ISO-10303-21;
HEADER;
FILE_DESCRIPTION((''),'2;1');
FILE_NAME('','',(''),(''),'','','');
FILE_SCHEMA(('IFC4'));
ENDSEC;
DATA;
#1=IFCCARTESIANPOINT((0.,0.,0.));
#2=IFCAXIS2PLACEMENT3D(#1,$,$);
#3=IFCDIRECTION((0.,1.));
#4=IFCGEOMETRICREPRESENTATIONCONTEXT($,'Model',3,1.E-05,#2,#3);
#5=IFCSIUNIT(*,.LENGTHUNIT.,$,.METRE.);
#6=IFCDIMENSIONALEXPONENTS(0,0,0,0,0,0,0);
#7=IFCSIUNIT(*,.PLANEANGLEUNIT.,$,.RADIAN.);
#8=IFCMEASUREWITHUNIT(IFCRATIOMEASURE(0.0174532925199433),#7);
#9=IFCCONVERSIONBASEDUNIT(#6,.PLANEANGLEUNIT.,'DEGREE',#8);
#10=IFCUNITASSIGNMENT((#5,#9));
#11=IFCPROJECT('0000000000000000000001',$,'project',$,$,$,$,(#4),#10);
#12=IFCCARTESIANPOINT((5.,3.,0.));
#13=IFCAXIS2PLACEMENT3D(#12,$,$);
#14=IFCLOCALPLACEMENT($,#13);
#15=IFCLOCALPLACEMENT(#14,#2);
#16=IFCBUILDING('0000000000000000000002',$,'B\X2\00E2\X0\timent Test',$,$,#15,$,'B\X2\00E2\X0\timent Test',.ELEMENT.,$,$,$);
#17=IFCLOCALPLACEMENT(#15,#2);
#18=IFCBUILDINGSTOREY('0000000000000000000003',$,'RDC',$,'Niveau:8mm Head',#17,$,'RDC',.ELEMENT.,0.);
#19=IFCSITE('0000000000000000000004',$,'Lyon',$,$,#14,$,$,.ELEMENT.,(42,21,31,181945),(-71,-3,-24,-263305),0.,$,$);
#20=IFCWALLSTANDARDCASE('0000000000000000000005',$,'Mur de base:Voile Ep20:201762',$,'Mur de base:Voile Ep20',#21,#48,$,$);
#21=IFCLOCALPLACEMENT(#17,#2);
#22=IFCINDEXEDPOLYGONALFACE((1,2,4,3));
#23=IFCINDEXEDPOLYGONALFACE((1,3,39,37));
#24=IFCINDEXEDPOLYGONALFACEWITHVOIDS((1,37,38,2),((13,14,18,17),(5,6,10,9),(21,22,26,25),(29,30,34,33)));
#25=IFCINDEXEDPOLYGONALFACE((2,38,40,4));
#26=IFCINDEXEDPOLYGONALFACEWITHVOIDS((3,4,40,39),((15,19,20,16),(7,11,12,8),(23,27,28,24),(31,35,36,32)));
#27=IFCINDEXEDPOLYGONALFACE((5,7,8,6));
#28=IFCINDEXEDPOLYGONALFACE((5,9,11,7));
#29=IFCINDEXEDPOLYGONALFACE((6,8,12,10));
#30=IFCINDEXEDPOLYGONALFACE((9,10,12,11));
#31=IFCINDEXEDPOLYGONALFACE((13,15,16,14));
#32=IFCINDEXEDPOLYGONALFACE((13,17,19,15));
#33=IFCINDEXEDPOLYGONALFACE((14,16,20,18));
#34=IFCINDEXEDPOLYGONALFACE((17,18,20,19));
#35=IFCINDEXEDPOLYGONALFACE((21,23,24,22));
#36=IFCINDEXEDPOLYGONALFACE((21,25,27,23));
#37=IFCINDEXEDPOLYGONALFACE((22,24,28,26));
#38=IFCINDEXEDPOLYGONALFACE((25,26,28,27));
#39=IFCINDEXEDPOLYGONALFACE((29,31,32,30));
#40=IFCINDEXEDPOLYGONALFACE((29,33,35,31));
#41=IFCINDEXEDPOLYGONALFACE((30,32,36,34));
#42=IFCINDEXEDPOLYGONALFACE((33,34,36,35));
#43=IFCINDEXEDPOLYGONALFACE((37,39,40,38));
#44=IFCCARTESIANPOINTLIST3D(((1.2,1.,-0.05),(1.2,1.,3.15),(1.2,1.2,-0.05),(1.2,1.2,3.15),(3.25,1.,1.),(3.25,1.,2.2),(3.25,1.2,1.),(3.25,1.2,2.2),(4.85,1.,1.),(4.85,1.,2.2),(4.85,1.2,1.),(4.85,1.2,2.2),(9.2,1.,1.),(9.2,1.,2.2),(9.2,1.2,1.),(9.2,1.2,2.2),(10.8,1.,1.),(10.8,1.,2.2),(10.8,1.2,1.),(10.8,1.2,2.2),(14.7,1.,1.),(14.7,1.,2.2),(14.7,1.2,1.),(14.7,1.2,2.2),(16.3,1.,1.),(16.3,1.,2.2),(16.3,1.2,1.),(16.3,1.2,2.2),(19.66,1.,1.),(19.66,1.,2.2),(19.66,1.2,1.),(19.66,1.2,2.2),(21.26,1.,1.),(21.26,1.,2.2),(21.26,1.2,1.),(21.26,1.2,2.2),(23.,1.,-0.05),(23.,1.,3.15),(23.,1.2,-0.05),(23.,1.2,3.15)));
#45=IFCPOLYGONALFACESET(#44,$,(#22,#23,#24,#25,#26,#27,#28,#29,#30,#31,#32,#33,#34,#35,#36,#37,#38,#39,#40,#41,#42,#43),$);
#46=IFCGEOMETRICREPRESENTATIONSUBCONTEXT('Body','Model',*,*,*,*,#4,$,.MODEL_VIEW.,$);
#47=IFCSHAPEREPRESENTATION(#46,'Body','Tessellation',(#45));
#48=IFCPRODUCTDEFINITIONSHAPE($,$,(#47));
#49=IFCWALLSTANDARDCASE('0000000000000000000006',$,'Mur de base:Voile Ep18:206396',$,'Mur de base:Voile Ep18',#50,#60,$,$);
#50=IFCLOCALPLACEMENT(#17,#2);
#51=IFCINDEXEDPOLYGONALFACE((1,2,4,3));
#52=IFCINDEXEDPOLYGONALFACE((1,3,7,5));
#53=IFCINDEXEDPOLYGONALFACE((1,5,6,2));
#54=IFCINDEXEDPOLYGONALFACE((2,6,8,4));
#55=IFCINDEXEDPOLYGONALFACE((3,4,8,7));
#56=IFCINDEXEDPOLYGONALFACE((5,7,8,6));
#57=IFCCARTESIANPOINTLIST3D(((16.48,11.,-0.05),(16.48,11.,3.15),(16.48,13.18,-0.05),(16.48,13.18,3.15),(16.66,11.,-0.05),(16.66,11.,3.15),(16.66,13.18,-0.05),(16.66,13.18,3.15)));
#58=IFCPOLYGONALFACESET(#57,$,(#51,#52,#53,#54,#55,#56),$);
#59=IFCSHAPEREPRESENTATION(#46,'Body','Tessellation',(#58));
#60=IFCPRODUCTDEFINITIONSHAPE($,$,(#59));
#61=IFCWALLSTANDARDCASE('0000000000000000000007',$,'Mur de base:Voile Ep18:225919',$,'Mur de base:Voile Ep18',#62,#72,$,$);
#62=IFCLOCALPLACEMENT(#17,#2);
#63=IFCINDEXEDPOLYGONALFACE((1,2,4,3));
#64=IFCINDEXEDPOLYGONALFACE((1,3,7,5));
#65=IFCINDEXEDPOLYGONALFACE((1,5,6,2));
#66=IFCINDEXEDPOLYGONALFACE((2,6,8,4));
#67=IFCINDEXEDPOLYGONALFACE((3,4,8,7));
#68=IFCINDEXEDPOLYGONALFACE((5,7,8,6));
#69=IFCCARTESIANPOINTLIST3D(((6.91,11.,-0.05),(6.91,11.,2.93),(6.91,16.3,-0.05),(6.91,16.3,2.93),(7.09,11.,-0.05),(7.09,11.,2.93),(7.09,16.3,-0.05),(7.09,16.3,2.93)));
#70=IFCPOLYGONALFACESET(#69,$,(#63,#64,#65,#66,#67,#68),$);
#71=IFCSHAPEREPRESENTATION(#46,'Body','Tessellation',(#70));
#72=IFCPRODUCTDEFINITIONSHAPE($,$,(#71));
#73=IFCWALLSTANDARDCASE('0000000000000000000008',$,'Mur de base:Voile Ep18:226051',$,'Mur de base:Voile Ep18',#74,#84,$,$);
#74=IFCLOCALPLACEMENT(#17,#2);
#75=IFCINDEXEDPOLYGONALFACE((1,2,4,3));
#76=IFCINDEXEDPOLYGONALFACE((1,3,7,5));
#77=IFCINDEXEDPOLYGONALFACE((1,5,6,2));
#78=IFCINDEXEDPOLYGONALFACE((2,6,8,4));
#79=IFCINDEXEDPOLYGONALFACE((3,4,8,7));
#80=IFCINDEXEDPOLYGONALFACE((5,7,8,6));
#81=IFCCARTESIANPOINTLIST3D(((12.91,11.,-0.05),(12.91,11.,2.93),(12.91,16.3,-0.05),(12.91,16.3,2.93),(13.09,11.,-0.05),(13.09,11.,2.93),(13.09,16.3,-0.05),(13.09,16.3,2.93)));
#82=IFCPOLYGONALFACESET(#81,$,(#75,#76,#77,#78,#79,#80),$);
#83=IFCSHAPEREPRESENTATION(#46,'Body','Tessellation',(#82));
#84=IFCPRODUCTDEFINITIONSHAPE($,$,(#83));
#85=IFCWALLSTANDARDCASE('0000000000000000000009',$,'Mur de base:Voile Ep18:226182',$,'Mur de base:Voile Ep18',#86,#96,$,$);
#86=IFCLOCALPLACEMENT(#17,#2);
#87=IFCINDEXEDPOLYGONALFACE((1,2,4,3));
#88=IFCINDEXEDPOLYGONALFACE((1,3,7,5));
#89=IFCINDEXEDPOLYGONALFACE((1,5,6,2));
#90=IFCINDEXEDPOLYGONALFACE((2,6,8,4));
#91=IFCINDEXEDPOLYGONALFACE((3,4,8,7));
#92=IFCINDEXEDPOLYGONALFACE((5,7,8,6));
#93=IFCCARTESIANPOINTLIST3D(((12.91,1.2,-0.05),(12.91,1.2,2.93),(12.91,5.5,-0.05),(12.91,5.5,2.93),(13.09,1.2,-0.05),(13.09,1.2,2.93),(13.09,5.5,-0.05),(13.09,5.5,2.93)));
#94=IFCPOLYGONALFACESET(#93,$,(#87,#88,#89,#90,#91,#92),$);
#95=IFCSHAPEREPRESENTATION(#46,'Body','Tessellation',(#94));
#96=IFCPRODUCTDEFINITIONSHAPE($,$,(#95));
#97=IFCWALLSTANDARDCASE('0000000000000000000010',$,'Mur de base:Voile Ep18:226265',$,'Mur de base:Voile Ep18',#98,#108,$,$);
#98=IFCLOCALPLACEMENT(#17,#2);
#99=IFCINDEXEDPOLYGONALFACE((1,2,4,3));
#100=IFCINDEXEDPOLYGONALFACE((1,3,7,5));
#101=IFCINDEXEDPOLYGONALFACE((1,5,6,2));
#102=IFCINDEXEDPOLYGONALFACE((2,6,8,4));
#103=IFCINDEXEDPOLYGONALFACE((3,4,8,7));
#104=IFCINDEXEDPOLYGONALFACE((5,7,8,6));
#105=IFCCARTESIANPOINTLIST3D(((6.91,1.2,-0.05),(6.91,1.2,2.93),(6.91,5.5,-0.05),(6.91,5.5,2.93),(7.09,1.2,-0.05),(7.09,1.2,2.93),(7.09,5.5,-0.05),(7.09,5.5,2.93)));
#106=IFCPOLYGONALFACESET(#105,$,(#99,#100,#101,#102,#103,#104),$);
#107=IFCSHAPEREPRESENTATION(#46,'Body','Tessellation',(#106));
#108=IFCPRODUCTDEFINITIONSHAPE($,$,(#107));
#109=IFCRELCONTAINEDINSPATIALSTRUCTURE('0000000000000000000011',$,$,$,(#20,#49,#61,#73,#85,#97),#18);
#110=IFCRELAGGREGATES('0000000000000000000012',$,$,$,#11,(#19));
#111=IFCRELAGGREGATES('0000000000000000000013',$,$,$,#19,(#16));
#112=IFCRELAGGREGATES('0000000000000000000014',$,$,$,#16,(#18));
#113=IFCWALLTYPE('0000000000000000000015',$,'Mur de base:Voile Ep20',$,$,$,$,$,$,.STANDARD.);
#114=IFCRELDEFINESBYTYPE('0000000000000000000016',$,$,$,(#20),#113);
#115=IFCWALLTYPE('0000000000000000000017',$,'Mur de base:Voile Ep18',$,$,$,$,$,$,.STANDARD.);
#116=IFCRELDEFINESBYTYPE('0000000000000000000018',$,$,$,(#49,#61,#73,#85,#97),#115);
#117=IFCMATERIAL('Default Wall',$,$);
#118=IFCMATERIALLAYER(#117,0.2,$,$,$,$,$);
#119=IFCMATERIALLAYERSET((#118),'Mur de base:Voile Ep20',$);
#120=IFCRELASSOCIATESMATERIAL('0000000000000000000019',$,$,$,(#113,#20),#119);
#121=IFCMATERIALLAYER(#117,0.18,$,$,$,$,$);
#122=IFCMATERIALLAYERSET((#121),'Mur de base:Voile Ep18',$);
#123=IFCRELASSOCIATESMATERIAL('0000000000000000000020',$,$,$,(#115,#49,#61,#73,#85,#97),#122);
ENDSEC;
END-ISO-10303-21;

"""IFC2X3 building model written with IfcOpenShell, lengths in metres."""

from ifc_helpers import new_model, entity, si_unit, converted_unit, direction, frame, frame_2d, origin, place, context, subcontext, project, spatial, rectangle, extrude, material, layer, layer_set, layer_usage, type_object, element, save


model = new_model("IFC2X3")

# Units and contexts
model_context = context("Model", 3, precision=1e-05, world=origin(), true_north=direction((0.0, 1.0)))
body_context = subcontext(model_context, "Body", "Model", "MODEL_VIEW")
ifc_project = project(units=[si_unit("LENGTHUNIT", "METRE"), converted_unit("PLANEANGLEUNIT", "DEGREE", entity("IfcRatioMeasure", 0.0174532925199433), si_unit("PLANEANGLEUNIT", "RADIAN"), dimensions=[0, 0, 0, 0, 0, 0, 0])], contexts=[model_context])

# Site, building, storey
site_placement = place(None, frame((5.0, 3.0, 0.0)))
site = spatial("IfcSite", under=ifc_project, at=site_placement, Name="Lyon", CompositionType="ELEMENT", RefLatitude=(42, 21, 31, 181945), RefLongitude=(-71, -3, -24, -263305), RefElevation=0.0)
building_placement = place(site_placement, origin())
building = spatial("IfcBuilding", under=site, at=building_placement, Name="Bâtiment Test", LongName="Bâtiment Test", CompositionType="ELEMENT")
storey_placement = place(building_placement, origin())
storey = spatial("IfcBuildingStorey", under=building, at=storey_placement, Name="RDC", ObjectType="Niveau:8mm Head", LongName="RDC", CompositionType="ELEMENT", Elevation=0.0)

# Shared definitions
ifc_material_1 = material(Name="Default Wall")
ifc_layer_1 = layer(ifc_material_1, 0.2)
ifc_layer_set_1 = layer_set([ifc_layer_1], Name="Mur de base:Voile Ep20")
wall_type_1 = type_object("IfcWallType", Name="Mur de base:Voile Ep20", PredefinedType="STANDARD", material=ifc_layer_set_1)

# Wall, openings
ifc_layer_usage_1 = layer_usage(ifc_layer_set_1, "AXIS2", "POSITIVE", -0.1)
wall_1_placement = place(storey_placement, frame((1.2, 1.1, -0.05)))
wall_1 = element("IfcWallStandardCase", 1, at=wall_1_placement, inside=storey, type_object=wall_type_1, material=ifc_layer_usage_1, Name="Mur de base:Voile Ep20:201762", ObjectType="Mur de base:Voile Ep20", context=body_context, shape_type="SweptSolid", body=[
    extrude(rectangle(XDim=21.8, YDim=0.2, at=frame_2d((10.9, 0.0), x_axis=(-1.0, 0.0))), origin(), (0.0, 0.0, 1.0), 3.2),
])
opening_1_placement = place(wall_1_placement, origin())
element("IfcOpeningElement", 2, at=opening_1_placement, cuts=wall_1, ObjectType="Opening", context=body_context, shape_type="SweptSolid", body=[
    extrude(rectangle(XDim=1.2, YDim=1.6, at=frame_2d((0.0, 0.0), x_axis=(0.0, 1.0))), frame((2.85, -0.1, 1.65), z_axis=(0.0, 1.0, 0.0), x_axis=(1.0, 0.0, 0.0)), (0.0, 0.0, 1.0), 0.2),
])
opening_2_placement = place(wall_1_placement, origin())
element("IfcOpeningElement", 3, at=opening_2_placement, cuts=wall_1, ObjectType="Opening", context=body_context, shape_type="SweptSolid", body=[
    extrude(rectangle(XDim=1.2, YDim=1.6, at=frame_2d((0.0, 0.0), x_axis=(1.0, 0.0))), frame((8.8, -0.1, 1.65), z_axis=(0.0, 1.0, 0.0), x_axis=(0.0, 0.0, -1.0)), (0.0, 0.0, 1.0), 0.2),
])
opening_3_placement = place(wall_1_placement, origin())
element("IfcOpeningElement", 4, at=opening_3_placement, cuts=wall_1, ObjectType="Opening", context=body_context, shape_type="SweptSolid", body=[
    extrude(rectangle(XDim=1.2, YDim=1.6, at=frame_2d((0.0, 0.0), x_axis=(0.0, 1.0))), frame((14.3, -0.1, 1.65), z_axis=(0.0, 1.0, 0.0), x_axis=(1.0, 0.0, 0.0)), (0.0, 0.0, 1.0), 0.2),
])
opening_4_placement = place(wall_1_placement, origin())
element("IfcOpeningElement", 5, at=opening_4_placement, cuts=wall_1, ObjectType="Opening", context=body_context, shape_type="SweptSolid", body=[
    extrude(rectangle(XDim=1.2, YDim=1.6, at=frame_2d((0.0, 0.0), x_axis=(1.0, 0.0))), frame((19.26, -0.1, 1.65), z_axis=(0.0, 1.0, 0.0), x_axis=(0.0, 0.0, -1.0)), (0.0, 0.0, 1.0), 0.2),
])

# Walls
ifc_layer_2 = layer(ifc_material_1, 0.18)
ifc_layer_set_2 = layer_set([ifc_layer_2], Name="Mur de base:Voile Ep18")
ifc_layer_usage_2 = layer_usage(ifc_layer_set_2, "AXIS2", "NEGATIVE", 0.09)
wall_type_2 = type_object("IfcWallType", Name="Mur de base:Voile Ep18", PredefinedType="STANDARD", material=ifc_layer_set_2)
wall_2_placement = place(storey_placement, frame((16.57, 13.18, -0.05), z_axis=(0.0, 0.0, 1.0), x_axis=(0.0, -1.0, 0.0)))
element("IfcWallStandardCase", 6, at=wall_2_placement, inside=storey, type_object=wall_type_2, material=ifc_layer_usage_2, Name="Mur de base:Voile Ep18:206396", ObjectType="Mur de base:Voile Ep18", context=body_context, shape_type="SweptSolid", body=[
    extrude(rectangle(XDim=2.18, YDim=0.18, at=frame_2d((1.09, 0.0), x_axis=(-1.0, 0.0))), origin(), (0.0, 0.0, 1.0), 3.2),
])
ifc_layer_usage_3 = layer_usage(ifc_layer_set_2, "AXIS2", "NEGATIVE", 0.09)
wall_3_placement = place(storey_placement, frame((7.0, 16.3, -0.05), z_axis=(0.0, 0.0, 1.0), x_axis=(0.0, -1.0, 0.0)))
element("IfcWallStandardCase", 7, at=wall_3_placement, inside=storey, type_object=wall_type_2, material=ifc_layer_usage_3, Name="Mur de base:Voile Ep18:225919", ObjectType="Mur de base:Voile Ep18", context=body_context, shape_type="SweptSolid", body=[
    extrude(rectangle(XDim=5.3, YDim=0.18, at=frame_2d((2.65, 0.0), x_axis=(-1.0, 0.0))), origin(), (0.0, 0.0, 1.0), 2.98),
])
ifc_layer_usage_4 = layer_usage(ifc_layer_set_2, "AXIS2", "NEGATIVE", 0.09)
wall_4_placement = place(storey_placement, frame((13.0, 16.3, -0.05), z_axis=(0.0, 0.0, 1.0), x_axis=(0.0, -1.0, 0.0)))
element("IfcWallStandardCase", 8, at=wall_4_placement, inside=storey, type_object=wall_type_2, material=ifc_layer_usage_4, Name="Mur de base:Voile Ep18:226051", ObjectType="Mur de base:Voile Ep18", context=body_context, shape_type="SweptSolid", body=[
    extrude(rectangle(XDim=5.3, YDim=0.18, at=frame_2d((2.65, 0.0), x_axis=(-1.0, 0.0))), origin(), (0.0, 0.0, 1.0), 2.98),
])
ifc_layer_usage_5 = layer_usage(ifc_layer_set_2, "AXIS2", "NEGATIVE", 0.09)
wall_5_placement = place(storey_placement, frame((13.0, 1.2, -0.05), z_axis=(0.0, 0.0, 1.0), x_axis=(0.0, 1.0, 0.0)))
element("IfcWallStandardCase", 9, at=wall_5_placement, inside=storey, type_object=wall_type_2, material=ifc_layer_usage_5, Name="Mur de base:Voile Ep18:226182", ObjectType="Mur de base:Voile Ep18", context=body_context, shape_type="SweptSolid", body=[
    extrude(rectangle(XDim=4.3, YDim=0.18, at=frame_2d((2.15, 0.0), x_axis=(-1.0, 0.0))), origin(), (0.0, 0.0, 1.0), 2.98),
])
ifc_layer_usage_6 = layer_usage(ifc_layer_set_2, "AXIS2", "NEGATIVE", 0.09)
wall_6_placement = place(storey_placement, frame((7.0, 1.2, -0.05), z_axis=(0.0, 0.0, 1.0), x_axis=(0.0, 1.0, 0.0)))
element("IfcWallStandardCase", 10, at=wall_6_placement, inside=storey, type_object=wall_type_2, material=ifc_layer_usage_6, Name="Mur de base:Voile Ep18:226265", ObjectType="Mur de base:Voile Ep18", context=body_context, shape_type="SweptSolid", body=[
    extrude(rectangle(XDim=4.3, YDim=0.18, at=frame_2d((2.15, 0.0), x_axis=(-1.0, 0.0))), origin(), (0.0, 0.0, 1.0), 2.98),
])

save(model, "model.ifc")
